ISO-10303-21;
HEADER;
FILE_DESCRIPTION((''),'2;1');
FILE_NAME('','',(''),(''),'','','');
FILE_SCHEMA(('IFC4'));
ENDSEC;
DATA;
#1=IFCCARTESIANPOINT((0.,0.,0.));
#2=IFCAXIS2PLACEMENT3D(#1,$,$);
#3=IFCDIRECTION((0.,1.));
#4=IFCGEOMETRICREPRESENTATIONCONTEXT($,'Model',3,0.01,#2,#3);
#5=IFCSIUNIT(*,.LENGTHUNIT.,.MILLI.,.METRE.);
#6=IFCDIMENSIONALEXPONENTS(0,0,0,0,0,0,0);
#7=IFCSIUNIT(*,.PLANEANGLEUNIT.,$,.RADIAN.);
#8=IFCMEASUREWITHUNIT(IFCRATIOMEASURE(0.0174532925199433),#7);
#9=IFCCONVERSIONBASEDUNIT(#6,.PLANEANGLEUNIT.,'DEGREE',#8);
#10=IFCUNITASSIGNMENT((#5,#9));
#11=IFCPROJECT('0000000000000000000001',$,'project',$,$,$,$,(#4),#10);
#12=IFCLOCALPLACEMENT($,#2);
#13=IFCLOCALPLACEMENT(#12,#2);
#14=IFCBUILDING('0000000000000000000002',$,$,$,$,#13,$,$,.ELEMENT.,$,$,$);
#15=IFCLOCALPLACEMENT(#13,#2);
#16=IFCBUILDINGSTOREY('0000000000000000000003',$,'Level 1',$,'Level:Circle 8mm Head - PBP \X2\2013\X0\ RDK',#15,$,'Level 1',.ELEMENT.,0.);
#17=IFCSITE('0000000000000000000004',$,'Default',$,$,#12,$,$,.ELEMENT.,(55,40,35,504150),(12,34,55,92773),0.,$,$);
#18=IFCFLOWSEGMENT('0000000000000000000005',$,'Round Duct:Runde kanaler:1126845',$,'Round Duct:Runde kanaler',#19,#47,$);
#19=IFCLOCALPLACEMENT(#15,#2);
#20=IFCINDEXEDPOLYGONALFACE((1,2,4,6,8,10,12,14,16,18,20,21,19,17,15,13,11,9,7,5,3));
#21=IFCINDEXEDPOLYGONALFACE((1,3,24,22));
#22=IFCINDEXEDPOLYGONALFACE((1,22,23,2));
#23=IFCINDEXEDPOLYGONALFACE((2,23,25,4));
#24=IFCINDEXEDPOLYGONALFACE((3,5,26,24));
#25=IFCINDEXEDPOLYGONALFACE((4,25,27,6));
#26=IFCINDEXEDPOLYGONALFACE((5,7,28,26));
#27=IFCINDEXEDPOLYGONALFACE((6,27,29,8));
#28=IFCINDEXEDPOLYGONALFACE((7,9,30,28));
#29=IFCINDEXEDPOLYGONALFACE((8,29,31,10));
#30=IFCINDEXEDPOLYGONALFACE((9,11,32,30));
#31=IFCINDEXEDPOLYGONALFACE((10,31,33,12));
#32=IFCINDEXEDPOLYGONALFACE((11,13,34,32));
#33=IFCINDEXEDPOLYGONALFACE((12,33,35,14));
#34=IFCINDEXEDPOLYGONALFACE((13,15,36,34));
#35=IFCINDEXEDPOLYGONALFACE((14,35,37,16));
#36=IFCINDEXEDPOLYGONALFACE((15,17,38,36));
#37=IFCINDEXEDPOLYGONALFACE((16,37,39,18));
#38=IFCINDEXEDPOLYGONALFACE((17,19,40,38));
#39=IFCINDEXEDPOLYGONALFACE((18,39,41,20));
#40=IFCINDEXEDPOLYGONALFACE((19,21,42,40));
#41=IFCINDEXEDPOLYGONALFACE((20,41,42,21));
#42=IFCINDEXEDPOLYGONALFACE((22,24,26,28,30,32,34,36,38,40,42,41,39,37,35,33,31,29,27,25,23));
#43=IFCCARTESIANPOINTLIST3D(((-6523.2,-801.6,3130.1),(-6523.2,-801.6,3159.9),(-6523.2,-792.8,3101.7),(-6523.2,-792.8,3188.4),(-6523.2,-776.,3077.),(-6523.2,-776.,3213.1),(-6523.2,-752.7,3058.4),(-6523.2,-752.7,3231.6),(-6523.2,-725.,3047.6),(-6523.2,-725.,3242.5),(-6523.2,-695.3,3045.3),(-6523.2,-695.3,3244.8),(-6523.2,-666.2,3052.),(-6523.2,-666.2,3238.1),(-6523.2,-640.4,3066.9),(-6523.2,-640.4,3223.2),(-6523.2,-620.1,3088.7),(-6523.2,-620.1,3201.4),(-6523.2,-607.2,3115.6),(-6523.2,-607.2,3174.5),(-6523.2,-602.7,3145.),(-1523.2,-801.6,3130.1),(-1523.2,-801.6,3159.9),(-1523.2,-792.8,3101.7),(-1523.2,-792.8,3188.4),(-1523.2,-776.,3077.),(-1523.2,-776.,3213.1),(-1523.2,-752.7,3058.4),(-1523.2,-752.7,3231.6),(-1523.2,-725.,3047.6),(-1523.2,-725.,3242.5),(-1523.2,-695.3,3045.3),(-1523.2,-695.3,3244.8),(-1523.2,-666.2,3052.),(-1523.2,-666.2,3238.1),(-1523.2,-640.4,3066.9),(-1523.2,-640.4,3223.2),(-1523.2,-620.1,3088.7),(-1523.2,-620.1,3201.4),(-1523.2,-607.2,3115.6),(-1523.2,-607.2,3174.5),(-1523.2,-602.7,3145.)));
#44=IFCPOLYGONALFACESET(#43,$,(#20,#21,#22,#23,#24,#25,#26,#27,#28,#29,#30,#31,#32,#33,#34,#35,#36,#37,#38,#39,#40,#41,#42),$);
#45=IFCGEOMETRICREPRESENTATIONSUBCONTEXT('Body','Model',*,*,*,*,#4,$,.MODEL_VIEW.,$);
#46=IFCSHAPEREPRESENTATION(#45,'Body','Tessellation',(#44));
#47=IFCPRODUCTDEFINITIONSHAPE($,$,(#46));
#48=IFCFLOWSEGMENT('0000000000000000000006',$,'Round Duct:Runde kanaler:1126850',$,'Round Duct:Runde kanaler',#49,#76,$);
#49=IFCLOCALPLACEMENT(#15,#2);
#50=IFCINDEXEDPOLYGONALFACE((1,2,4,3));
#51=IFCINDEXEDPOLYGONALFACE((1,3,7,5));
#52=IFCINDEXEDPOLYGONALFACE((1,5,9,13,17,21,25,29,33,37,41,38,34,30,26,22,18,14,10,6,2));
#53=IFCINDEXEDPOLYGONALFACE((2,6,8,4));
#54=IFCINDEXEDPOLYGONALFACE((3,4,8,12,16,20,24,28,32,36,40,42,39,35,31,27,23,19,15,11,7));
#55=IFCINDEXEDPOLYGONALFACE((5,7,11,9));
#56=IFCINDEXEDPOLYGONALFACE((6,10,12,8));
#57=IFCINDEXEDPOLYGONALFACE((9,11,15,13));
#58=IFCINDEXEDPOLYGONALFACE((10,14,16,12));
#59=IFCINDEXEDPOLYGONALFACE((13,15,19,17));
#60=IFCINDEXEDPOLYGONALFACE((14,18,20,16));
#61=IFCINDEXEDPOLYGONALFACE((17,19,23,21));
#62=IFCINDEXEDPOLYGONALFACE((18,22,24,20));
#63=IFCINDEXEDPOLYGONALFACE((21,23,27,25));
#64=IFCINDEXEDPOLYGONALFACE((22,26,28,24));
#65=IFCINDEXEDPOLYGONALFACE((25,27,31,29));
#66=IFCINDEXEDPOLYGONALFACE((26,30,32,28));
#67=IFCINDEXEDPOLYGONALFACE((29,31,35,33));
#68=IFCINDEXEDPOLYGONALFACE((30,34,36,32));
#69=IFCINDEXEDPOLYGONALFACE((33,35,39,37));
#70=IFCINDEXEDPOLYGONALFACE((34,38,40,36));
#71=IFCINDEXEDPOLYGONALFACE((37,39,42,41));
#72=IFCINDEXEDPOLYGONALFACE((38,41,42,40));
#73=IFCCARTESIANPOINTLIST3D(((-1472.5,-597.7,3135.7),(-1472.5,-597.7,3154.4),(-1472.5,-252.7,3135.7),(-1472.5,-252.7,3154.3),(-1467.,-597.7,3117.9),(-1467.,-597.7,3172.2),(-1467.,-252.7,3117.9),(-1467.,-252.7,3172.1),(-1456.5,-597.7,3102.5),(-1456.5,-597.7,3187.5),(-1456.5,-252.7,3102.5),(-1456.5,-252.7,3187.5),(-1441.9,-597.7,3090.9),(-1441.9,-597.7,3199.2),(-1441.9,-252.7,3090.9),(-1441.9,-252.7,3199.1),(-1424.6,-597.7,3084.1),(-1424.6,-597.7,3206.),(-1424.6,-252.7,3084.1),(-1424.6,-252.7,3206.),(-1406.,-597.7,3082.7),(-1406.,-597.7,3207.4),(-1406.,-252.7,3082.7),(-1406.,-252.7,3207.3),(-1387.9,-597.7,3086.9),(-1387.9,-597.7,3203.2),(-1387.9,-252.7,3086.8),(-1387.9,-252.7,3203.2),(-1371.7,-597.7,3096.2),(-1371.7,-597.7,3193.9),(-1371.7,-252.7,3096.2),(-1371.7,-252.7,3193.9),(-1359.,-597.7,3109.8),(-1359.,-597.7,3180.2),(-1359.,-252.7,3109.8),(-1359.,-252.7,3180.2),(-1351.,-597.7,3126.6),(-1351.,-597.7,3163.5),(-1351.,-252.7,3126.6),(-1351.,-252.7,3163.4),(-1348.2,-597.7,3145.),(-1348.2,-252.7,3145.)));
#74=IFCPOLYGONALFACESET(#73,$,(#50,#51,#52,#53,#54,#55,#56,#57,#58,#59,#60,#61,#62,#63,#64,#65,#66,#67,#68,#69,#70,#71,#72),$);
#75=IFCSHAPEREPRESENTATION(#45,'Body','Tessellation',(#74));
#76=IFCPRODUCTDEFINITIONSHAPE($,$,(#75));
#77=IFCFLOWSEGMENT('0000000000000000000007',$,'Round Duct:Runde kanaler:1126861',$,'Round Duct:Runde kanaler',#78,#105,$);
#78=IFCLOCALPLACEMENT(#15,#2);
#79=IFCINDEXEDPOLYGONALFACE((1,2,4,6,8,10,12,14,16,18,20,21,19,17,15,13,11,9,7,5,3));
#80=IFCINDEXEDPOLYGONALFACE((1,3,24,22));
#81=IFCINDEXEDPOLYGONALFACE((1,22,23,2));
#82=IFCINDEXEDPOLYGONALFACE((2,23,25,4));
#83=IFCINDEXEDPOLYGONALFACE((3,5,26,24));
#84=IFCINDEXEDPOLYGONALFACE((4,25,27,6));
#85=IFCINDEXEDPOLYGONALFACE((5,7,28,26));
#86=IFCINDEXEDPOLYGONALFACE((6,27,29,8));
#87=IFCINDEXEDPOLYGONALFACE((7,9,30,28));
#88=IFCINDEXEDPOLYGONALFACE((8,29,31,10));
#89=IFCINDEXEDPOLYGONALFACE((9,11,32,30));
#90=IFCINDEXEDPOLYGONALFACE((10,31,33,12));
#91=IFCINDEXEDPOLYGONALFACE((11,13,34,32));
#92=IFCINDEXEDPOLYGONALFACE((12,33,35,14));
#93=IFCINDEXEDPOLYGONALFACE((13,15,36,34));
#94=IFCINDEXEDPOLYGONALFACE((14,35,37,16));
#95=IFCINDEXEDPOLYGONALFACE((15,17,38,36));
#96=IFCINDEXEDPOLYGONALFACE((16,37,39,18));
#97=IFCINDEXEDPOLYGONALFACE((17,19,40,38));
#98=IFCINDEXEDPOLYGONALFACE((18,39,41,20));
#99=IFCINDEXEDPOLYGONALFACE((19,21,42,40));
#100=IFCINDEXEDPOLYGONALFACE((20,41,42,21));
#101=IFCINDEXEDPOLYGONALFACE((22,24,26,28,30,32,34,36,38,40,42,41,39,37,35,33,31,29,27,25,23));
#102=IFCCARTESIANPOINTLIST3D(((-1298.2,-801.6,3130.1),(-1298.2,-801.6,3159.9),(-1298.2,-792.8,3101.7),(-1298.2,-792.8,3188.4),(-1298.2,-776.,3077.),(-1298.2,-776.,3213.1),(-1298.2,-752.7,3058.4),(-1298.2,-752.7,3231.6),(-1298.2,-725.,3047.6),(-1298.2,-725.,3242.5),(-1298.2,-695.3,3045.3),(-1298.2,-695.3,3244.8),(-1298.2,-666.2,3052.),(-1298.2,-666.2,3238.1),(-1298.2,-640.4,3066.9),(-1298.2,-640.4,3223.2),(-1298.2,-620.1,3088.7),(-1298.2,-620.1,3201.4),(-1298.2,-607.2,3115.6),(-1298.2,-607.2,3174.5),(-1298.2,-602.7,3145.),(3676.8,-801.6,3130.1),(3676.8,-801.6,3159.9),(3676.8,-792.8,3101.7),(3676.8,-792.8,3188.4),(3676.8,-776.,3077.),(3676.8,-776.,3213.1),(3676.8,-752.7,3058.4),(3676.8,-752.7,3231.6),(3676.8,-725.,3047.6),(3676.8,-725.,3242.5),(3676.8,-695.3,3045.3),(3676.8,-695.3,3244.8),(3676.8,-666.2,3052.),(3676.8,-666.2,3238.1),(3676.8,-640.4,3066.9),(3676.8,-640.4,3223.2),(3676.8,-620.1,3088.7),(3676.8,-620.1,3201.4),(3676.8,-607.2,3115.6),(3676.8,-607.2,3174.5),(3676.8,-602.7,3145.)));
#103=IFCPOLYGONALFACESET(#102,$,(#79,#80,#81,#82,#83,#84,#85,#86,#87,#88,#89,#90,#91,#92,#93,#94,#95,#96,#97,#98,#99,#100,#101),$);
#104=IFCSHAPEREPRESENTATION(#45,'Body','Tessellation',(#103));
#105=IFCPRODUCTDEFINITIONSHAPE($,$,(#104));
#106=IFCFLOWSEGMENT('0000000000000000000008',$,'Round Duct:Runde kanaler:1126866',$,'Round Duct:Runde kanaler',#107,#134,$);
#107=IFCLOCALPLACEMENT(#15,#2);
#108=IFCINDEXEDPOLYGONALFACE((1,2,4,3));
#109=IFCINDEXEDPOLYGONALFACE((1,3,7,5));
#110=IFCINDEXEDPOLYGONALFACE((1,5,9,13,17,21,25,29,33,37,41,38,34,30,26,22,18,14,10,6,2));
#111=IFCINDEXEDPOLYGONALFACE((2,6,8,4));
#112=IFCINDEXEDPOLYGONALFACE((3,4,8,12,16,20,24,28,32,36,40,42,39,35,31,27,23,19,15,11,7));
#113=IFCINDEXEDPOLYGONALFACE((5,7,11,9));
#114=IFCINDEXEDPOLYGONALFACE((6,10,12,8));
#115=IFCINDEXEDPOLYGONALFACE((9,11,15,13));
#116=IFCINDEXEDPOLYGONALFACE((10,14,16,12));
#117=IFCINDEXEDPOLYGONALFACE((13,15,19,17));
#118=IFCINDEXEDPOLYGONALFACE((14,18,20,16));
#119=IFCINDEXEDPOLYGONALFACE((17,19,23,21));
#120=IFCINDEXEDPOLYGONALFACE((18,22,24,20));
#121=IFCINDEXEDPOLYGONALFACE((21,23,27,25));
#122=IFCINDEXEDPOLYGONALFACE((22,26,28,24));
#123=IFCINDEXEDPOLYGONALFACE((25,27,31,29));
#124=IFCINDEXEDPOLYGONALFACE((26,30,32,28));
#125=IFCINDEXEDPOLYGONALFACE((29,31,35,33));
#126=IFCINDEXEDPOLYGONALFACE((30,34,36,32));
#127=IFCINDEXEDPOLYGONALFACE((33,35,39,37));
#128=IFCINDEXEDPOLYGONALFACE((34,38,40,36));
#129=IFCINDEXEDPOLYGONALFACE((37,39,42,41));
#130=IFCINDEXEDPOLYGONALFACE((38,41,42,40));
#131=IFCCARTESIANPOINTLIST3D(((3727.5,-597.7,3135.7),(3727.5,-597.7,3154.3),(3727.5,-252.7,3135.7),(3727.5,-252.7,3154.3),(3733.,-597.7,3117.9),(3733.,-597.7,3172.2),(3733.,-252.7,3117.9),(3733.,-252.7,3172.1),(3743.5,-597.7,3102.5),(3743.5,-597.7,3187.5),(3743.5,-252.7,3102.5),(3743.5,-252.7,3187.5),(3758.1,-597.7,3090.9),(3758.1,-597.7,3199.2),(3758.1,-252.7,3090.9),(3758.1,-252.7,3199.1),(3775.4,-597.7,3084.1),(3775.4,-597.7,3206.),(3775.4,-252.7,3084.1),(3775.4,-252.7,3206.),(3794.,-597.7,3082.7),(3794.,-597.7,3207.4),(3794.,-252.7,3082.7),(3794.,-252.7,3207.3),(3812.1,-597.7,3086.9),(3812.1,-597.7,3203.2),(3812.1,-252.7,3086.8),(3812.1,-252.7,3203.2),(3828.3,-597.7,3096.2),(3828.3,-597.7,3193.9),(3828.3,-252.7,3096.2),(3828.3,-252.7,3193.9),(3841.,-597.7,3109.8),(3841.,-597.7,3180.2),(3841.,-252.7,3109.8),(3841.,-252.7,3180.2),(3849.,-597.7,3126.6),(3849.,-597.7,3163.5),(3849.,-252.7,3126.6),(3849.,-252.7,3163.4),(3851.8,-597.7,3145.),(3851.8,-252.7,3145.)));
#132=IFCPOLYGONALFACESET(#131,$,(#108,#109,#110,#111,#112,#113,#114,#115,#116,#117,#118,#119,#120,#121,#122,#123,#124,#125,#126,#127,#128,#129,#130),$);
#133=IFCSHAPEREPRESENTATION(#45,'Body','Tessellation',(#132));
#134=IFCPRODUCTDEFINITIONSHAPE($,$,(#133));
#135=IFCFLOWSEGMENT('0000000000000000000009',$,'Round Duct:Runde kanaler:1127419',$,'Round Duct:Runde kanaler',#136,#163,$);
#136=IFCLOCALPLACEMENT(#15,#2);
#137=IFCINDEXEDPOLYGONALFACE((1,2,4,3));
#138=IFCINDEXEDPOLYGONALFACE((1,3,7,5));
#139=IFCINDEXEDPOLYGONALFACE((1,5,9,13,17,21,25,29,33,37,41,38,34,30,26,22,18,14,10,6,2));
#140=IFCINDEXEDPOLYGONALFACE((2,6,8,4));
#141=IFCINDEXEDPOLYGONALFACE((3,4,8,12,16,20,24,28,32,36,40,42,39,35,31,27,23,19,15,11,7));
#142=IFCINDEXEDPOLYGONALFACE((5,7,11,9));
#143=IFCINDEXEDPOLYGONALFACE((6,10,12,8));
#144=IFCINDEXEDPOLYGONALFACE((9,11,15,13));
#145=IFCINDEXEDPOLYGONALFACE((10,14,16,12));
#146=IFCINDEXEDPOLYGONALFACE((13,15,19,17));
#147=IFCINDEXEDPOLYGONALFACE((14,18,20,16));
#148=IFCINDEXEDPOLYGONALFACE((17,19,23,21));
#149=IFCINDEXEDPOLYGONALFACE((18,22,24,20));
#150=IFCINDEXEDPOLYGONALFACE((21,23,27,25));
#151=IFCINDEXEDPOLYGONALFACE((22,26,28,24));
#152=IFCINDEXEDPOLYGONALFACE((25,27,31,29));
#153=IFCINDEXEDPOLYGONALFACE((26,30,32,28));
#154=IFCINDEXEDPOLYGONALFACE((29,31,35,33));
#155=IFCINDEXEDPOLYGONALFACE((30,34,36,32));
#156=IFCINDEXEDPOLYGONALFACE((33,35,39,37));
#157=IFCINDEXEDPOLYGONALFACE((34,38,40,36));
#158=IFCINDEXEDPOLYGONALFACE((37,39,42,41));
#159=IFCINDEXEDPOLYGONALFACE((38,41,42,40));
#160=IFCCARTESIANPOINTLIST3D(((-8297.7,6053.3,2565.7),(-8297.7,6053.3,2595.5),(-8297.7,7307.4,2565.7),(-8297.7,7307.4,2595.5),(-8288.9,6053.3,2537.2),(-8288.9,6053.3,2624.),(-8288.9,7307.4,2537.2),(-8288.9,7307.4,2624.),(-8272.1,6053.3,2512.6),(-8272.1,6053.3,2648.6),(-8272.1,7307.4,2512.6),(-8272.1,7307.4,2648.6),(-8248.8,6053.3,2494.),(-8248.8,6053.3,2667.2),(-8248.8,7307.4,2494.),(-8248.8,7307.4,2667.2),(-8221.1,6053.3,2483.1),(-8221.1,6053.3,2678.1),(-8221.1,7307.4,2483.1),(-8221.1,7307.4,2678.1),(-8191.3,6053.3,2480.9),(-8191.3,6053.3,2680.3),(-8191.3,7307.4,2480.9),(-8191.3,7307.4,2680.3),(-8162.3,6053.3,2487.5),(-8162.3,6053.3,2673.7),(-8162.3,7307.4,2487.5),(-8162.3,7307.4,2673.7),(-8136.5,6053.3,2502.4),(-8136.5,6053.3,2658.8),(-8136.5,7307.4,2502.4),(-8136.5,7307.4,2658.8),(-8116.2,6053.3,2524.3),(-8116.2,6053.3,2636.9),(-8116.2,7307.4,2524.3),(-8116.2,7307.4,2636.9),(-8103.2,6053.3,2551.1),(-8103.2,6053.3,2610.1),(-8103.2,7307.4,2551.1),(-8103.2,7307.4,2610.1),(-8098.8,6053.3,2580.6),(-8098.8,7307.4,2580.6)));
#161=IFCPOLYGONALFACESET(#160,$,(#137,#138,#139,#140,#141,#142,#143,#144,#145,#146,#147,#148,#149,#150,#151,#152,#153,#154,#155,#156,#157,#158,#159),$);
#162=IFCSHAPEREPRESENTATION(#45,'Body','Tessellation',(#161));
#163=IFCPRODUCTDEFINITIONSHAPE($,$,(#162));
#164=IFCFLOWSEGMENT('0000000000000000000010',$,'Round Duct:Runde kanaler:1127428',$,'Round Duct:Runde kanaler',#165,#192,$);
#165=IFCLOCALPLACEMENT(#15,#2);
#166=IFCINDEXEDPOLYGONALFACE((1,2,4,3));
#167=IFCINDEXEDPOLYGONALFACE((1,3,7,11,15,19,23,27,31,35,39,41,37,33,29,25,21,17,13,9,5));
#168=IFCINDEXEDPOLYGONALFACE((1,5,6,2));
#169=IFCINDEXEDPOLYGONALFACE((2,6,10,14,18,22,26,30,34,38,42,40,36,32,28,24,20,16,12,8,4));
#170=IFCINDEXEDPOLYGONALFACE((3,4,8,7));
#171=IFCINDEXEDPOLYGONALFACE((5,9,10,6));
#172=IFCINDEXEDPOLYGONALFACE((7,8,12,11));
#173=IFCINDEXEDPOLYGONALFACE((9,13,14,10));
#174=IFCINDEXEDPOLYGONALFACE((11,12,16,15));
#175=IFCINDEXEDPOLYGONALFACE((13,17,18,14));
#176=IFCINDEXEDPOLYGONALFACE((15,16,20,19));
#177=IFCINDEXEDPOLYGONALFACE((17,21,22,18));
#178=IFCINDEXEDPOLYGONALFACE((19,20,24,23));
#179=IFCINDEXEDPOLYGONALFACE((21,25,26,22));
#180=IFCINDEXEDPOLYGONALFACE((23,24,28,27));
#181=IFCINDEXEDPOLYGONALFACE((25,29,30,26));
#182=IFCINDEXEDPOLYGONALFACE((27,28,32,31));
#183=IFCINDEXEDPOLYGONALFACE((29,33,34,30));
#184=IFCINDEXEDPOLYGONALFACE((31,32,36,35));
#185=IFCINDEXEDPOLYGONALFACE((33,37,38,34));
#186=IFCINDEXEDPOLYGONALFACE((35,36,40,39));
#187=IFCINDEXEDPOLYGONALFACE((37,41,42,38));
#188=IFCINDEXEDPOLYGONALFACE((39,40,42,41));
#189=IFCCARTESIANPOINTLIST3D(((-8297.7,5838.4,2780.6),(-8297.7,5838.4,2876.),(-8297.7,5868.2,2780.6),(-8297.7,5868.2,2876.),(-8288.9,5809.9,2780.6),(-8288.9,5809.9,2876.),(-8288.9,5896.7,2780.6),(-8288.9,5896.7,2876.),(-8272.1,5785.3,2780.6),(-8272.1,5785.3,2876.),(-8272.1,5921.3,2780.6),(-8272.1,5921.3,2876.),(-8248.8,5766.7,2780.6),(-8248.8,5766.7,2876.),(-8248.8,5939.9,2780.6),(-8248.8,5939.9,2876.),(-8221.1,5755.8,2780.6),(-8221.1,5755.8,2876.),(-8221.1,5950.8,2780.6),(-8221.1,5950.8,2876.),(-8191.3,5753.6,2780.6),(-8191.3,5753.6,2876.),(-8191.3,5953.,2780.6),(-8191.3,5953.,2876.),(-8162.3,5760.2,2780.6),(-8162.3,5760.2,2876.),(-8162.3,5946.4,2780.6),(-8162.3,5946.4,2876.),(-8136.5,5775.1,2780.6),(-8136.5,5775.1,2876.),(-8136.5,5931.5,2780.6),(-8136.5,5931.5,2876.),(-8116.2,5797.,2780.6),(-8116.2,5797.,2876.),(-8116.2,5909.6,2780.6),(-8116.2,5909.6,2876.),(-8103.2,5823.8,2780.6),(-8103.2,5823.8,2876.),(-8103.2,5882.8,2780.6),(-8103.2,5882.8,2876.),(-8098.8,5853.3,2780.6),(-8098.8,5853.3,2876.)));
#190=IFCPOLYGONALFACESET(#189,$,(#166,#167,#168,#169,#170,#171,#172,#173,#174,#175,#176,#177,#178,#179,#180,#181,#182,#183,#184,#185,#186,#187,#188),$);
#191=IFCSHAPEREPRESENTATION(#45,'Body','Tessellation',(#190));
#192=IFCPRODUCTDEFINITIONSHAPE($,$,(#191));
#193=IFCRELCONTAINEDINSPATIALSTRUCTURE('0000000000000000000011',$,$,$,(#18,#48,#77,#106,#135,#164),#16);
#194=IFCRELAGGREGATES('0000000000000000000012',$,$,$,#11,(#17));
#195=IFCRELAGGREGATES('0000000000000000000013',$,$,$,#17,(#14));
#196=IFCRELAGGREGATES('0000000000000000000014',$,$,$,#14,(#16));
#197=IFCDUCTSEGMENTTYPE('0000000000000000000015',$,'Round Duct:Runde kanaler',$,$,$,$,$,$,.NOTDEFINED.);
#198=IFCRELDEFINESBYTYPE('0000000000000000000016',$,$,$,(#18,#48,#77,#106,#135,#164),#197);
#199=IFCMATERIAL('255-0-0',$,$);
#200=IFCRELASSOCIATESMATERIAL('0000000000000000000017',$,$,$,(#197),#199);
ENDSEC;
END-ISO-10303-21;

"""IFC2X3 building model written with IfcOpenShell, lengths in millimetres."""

from ifc_helpers import new_model, entity, si_unit, converted_unit, direction, frame, frame_2d, origin, place, context, subcontext, project, spatial, circle, extrude, material, type_object, element, save


model = new_model("IFC2X3")

# Units and contexts
model_context = context("Model", 3, precision=0.01, world=origin(), true_north=direction((0.0, 1.0)))
body_context = subcontext(model_context, "Body", "Model", "MODEL_VIEW")
ifc_project = project(units=[si_unit("LENGTHUNIT", "METRE", prefix="MILLI"), converted_unit("PLANEANGLEUNIT", "DEGREE", entity("IfcRatioMeasure", 0.0174532925199433), si_unit("PLANEANGLEUNIT", "RADIAN"), dimensions=[0, 0, 0, 0, 0, 0, 0])], contexts=[model_context])

# Site, building, storey
site_placement = place(None, origin())
site = spatial("IfcSite", under=ifc_project, at=site_placement, Name="Default", CompositionType="ELEMENT", RefLatitude=(55, 40, 35, 504150), RefLongitude=(12, 34, 55, 92773), RefElevation=0.0)
building_placement = place(site_placement, origin())
building = spatial("IfcBuilding", under=site, at=building_placement, CompositionType="ELEMENT")
storey_placement = place(building_placement, origin())
storey = spatial("IfcBuildingStorey", under=building, at=storey_placement, Name="Level 1", ObjectType="Level:Circle 8mm Head - PBP – RDK", LongName="Level 1", CompositionType="ELEMENT", Elevation=0.0)

# Flow segments
ifc_material_1 = material(Name="255-0-0")
duct_segment_type = type_object("IfcDuctSegmentType", Name="Round Duct:Runde kanaler", PredefinedType="NOTDEFINED", material=ifc_material_1)
flow_segment_1_placement = place(storey_placement, origin())
element("IfcFlowSegment", 1, at=flow_segment_1_placement, inside=storey, type_object=duct_segment_type, Name="Round Duct:Runde kanaler:1126845", ObjectType="Round Duct:Runde kanaler", context=body_context, shape_type="SweptSolid", body=[
    extrude(circle(Radius=100.0, at=frame_2d((0.0, 0.0), x_axis=(1.0, 0.0))), frame((-6523.2, -702.7, 3145.0), z_axis=(1.0, 0.0, 0.0), x_axis=(0.0, 1.0, 0.0)), (0.0, 0.0, 1.0), 5000.0),
])
flow_segment_2_placement = place(storey_placement, origin())
element("IfcFlowSegment", 2, at=flow_segment_2_placement, inside=storey, type_object=duct_segment_type, Name="Round Duct:Runde kanaler:1126850", ObjectType="Round Duct:Runde kanaler", context=body_context, shape_type="SweptSolid", body=[
    extrude(circle(Radius=62.5, at=frame_2d((0.0, 0.0), x_axis=(1.0, 0.0))), frame((-1410.7, -252.7, 3145.0), z_axis=(0.0, -1.0, 0.000044), x_axis=(1.0, 0.0, 0.0)), (0.0, 0.0, 1.0), 345.0),
])
flow_segment_3_placement = place(storey_placement, origin())
element("IfcFlowSegment", 3, at=flow_segment_3_placement, inside=storey, type_object=duct_segment_type, Name="Round Duct:Runde kanaler:1126861", ObjectType="Round Duct:Runde kanaler", context=body_context, shape_type="SweptSolid", body=[
    extrude(circle(Radius=100.0, at=frame_2d((0.0, 0.0), x_axis=(1.0, 0.0))), frame((-1298.2, -702.7, 3145.0), z_axis=(1.0, 0.0, 0.0), x_axis=(0.0, 1.0, 0.0)), (0.0, 0.0, 1.0), 4975.0),
])
flow_segment_4_placement = place(storey_placement, origin())
element("IfcFlowSegment", 4, at=flow_segment_4_placement, inside=storey, type_object=duct_segment_type, Name="Round Duct:Runde kanaler:1126866", ObjectType="Round Duct:Runde kanaler", context=body_context, shape_type="SweptSolid", body=[
    extrude(circle(Radius=62.5, at=frame_2d((0.0, 0.0), x_axis=(1.0, 0.0))), frame((3789.3, -597.7, 3145.0), z_axis=(0.0, 1.0, -0.000037), x_axis=(1.0, 0.0, 0.0)), (0.0, 0.0, 1.0), 345.0),
])
flow_segment_5_placement = place(storey_placement, origin())
element("IfcFlowSegment", 5, at=flow_segment_5_placement, inside=storey, type_object=duct_segment_type, Name="Round Duct:Runde kanaler:1127419", ObjectType="Round Duct:Runde kanaler", context=body_context, shape_type="SweptSolid", body=[
    extrude(circle(Radius=100.0, at=frame_2d((0.0, 0.0), x_axis=(1.0, 0.0))), frame((-8198.8, 6053.3, 2580.6), z_axis=(0.0, 1.0, 0.0), x_axis=(1.0, 0.0, 0.0)), (0.0, 0.0, 1.0), 1254.1),
])
flow_segment_6_placement = place(storey_placement, origin())
element("IfcFlowSegment", 6, at=flow_segment_6_placement, inside=storey, type_object=duct_segment_type, Name="Round Duct:Runde kanaler:1127428", ObjectType="Round Duct:Runde kanaler", context=body_context, shape_type="SweptSolid", body=[
    extrude(circle(Radius=100.0, at=frame_2d((0.0, 0.0), x_axis=(1.0, 0.0))), frame((-8198.8, 5853.3, 2780.6)), (0.0, 0.0, 1.0), 95.4),
])

save(model, "model.ifc")
